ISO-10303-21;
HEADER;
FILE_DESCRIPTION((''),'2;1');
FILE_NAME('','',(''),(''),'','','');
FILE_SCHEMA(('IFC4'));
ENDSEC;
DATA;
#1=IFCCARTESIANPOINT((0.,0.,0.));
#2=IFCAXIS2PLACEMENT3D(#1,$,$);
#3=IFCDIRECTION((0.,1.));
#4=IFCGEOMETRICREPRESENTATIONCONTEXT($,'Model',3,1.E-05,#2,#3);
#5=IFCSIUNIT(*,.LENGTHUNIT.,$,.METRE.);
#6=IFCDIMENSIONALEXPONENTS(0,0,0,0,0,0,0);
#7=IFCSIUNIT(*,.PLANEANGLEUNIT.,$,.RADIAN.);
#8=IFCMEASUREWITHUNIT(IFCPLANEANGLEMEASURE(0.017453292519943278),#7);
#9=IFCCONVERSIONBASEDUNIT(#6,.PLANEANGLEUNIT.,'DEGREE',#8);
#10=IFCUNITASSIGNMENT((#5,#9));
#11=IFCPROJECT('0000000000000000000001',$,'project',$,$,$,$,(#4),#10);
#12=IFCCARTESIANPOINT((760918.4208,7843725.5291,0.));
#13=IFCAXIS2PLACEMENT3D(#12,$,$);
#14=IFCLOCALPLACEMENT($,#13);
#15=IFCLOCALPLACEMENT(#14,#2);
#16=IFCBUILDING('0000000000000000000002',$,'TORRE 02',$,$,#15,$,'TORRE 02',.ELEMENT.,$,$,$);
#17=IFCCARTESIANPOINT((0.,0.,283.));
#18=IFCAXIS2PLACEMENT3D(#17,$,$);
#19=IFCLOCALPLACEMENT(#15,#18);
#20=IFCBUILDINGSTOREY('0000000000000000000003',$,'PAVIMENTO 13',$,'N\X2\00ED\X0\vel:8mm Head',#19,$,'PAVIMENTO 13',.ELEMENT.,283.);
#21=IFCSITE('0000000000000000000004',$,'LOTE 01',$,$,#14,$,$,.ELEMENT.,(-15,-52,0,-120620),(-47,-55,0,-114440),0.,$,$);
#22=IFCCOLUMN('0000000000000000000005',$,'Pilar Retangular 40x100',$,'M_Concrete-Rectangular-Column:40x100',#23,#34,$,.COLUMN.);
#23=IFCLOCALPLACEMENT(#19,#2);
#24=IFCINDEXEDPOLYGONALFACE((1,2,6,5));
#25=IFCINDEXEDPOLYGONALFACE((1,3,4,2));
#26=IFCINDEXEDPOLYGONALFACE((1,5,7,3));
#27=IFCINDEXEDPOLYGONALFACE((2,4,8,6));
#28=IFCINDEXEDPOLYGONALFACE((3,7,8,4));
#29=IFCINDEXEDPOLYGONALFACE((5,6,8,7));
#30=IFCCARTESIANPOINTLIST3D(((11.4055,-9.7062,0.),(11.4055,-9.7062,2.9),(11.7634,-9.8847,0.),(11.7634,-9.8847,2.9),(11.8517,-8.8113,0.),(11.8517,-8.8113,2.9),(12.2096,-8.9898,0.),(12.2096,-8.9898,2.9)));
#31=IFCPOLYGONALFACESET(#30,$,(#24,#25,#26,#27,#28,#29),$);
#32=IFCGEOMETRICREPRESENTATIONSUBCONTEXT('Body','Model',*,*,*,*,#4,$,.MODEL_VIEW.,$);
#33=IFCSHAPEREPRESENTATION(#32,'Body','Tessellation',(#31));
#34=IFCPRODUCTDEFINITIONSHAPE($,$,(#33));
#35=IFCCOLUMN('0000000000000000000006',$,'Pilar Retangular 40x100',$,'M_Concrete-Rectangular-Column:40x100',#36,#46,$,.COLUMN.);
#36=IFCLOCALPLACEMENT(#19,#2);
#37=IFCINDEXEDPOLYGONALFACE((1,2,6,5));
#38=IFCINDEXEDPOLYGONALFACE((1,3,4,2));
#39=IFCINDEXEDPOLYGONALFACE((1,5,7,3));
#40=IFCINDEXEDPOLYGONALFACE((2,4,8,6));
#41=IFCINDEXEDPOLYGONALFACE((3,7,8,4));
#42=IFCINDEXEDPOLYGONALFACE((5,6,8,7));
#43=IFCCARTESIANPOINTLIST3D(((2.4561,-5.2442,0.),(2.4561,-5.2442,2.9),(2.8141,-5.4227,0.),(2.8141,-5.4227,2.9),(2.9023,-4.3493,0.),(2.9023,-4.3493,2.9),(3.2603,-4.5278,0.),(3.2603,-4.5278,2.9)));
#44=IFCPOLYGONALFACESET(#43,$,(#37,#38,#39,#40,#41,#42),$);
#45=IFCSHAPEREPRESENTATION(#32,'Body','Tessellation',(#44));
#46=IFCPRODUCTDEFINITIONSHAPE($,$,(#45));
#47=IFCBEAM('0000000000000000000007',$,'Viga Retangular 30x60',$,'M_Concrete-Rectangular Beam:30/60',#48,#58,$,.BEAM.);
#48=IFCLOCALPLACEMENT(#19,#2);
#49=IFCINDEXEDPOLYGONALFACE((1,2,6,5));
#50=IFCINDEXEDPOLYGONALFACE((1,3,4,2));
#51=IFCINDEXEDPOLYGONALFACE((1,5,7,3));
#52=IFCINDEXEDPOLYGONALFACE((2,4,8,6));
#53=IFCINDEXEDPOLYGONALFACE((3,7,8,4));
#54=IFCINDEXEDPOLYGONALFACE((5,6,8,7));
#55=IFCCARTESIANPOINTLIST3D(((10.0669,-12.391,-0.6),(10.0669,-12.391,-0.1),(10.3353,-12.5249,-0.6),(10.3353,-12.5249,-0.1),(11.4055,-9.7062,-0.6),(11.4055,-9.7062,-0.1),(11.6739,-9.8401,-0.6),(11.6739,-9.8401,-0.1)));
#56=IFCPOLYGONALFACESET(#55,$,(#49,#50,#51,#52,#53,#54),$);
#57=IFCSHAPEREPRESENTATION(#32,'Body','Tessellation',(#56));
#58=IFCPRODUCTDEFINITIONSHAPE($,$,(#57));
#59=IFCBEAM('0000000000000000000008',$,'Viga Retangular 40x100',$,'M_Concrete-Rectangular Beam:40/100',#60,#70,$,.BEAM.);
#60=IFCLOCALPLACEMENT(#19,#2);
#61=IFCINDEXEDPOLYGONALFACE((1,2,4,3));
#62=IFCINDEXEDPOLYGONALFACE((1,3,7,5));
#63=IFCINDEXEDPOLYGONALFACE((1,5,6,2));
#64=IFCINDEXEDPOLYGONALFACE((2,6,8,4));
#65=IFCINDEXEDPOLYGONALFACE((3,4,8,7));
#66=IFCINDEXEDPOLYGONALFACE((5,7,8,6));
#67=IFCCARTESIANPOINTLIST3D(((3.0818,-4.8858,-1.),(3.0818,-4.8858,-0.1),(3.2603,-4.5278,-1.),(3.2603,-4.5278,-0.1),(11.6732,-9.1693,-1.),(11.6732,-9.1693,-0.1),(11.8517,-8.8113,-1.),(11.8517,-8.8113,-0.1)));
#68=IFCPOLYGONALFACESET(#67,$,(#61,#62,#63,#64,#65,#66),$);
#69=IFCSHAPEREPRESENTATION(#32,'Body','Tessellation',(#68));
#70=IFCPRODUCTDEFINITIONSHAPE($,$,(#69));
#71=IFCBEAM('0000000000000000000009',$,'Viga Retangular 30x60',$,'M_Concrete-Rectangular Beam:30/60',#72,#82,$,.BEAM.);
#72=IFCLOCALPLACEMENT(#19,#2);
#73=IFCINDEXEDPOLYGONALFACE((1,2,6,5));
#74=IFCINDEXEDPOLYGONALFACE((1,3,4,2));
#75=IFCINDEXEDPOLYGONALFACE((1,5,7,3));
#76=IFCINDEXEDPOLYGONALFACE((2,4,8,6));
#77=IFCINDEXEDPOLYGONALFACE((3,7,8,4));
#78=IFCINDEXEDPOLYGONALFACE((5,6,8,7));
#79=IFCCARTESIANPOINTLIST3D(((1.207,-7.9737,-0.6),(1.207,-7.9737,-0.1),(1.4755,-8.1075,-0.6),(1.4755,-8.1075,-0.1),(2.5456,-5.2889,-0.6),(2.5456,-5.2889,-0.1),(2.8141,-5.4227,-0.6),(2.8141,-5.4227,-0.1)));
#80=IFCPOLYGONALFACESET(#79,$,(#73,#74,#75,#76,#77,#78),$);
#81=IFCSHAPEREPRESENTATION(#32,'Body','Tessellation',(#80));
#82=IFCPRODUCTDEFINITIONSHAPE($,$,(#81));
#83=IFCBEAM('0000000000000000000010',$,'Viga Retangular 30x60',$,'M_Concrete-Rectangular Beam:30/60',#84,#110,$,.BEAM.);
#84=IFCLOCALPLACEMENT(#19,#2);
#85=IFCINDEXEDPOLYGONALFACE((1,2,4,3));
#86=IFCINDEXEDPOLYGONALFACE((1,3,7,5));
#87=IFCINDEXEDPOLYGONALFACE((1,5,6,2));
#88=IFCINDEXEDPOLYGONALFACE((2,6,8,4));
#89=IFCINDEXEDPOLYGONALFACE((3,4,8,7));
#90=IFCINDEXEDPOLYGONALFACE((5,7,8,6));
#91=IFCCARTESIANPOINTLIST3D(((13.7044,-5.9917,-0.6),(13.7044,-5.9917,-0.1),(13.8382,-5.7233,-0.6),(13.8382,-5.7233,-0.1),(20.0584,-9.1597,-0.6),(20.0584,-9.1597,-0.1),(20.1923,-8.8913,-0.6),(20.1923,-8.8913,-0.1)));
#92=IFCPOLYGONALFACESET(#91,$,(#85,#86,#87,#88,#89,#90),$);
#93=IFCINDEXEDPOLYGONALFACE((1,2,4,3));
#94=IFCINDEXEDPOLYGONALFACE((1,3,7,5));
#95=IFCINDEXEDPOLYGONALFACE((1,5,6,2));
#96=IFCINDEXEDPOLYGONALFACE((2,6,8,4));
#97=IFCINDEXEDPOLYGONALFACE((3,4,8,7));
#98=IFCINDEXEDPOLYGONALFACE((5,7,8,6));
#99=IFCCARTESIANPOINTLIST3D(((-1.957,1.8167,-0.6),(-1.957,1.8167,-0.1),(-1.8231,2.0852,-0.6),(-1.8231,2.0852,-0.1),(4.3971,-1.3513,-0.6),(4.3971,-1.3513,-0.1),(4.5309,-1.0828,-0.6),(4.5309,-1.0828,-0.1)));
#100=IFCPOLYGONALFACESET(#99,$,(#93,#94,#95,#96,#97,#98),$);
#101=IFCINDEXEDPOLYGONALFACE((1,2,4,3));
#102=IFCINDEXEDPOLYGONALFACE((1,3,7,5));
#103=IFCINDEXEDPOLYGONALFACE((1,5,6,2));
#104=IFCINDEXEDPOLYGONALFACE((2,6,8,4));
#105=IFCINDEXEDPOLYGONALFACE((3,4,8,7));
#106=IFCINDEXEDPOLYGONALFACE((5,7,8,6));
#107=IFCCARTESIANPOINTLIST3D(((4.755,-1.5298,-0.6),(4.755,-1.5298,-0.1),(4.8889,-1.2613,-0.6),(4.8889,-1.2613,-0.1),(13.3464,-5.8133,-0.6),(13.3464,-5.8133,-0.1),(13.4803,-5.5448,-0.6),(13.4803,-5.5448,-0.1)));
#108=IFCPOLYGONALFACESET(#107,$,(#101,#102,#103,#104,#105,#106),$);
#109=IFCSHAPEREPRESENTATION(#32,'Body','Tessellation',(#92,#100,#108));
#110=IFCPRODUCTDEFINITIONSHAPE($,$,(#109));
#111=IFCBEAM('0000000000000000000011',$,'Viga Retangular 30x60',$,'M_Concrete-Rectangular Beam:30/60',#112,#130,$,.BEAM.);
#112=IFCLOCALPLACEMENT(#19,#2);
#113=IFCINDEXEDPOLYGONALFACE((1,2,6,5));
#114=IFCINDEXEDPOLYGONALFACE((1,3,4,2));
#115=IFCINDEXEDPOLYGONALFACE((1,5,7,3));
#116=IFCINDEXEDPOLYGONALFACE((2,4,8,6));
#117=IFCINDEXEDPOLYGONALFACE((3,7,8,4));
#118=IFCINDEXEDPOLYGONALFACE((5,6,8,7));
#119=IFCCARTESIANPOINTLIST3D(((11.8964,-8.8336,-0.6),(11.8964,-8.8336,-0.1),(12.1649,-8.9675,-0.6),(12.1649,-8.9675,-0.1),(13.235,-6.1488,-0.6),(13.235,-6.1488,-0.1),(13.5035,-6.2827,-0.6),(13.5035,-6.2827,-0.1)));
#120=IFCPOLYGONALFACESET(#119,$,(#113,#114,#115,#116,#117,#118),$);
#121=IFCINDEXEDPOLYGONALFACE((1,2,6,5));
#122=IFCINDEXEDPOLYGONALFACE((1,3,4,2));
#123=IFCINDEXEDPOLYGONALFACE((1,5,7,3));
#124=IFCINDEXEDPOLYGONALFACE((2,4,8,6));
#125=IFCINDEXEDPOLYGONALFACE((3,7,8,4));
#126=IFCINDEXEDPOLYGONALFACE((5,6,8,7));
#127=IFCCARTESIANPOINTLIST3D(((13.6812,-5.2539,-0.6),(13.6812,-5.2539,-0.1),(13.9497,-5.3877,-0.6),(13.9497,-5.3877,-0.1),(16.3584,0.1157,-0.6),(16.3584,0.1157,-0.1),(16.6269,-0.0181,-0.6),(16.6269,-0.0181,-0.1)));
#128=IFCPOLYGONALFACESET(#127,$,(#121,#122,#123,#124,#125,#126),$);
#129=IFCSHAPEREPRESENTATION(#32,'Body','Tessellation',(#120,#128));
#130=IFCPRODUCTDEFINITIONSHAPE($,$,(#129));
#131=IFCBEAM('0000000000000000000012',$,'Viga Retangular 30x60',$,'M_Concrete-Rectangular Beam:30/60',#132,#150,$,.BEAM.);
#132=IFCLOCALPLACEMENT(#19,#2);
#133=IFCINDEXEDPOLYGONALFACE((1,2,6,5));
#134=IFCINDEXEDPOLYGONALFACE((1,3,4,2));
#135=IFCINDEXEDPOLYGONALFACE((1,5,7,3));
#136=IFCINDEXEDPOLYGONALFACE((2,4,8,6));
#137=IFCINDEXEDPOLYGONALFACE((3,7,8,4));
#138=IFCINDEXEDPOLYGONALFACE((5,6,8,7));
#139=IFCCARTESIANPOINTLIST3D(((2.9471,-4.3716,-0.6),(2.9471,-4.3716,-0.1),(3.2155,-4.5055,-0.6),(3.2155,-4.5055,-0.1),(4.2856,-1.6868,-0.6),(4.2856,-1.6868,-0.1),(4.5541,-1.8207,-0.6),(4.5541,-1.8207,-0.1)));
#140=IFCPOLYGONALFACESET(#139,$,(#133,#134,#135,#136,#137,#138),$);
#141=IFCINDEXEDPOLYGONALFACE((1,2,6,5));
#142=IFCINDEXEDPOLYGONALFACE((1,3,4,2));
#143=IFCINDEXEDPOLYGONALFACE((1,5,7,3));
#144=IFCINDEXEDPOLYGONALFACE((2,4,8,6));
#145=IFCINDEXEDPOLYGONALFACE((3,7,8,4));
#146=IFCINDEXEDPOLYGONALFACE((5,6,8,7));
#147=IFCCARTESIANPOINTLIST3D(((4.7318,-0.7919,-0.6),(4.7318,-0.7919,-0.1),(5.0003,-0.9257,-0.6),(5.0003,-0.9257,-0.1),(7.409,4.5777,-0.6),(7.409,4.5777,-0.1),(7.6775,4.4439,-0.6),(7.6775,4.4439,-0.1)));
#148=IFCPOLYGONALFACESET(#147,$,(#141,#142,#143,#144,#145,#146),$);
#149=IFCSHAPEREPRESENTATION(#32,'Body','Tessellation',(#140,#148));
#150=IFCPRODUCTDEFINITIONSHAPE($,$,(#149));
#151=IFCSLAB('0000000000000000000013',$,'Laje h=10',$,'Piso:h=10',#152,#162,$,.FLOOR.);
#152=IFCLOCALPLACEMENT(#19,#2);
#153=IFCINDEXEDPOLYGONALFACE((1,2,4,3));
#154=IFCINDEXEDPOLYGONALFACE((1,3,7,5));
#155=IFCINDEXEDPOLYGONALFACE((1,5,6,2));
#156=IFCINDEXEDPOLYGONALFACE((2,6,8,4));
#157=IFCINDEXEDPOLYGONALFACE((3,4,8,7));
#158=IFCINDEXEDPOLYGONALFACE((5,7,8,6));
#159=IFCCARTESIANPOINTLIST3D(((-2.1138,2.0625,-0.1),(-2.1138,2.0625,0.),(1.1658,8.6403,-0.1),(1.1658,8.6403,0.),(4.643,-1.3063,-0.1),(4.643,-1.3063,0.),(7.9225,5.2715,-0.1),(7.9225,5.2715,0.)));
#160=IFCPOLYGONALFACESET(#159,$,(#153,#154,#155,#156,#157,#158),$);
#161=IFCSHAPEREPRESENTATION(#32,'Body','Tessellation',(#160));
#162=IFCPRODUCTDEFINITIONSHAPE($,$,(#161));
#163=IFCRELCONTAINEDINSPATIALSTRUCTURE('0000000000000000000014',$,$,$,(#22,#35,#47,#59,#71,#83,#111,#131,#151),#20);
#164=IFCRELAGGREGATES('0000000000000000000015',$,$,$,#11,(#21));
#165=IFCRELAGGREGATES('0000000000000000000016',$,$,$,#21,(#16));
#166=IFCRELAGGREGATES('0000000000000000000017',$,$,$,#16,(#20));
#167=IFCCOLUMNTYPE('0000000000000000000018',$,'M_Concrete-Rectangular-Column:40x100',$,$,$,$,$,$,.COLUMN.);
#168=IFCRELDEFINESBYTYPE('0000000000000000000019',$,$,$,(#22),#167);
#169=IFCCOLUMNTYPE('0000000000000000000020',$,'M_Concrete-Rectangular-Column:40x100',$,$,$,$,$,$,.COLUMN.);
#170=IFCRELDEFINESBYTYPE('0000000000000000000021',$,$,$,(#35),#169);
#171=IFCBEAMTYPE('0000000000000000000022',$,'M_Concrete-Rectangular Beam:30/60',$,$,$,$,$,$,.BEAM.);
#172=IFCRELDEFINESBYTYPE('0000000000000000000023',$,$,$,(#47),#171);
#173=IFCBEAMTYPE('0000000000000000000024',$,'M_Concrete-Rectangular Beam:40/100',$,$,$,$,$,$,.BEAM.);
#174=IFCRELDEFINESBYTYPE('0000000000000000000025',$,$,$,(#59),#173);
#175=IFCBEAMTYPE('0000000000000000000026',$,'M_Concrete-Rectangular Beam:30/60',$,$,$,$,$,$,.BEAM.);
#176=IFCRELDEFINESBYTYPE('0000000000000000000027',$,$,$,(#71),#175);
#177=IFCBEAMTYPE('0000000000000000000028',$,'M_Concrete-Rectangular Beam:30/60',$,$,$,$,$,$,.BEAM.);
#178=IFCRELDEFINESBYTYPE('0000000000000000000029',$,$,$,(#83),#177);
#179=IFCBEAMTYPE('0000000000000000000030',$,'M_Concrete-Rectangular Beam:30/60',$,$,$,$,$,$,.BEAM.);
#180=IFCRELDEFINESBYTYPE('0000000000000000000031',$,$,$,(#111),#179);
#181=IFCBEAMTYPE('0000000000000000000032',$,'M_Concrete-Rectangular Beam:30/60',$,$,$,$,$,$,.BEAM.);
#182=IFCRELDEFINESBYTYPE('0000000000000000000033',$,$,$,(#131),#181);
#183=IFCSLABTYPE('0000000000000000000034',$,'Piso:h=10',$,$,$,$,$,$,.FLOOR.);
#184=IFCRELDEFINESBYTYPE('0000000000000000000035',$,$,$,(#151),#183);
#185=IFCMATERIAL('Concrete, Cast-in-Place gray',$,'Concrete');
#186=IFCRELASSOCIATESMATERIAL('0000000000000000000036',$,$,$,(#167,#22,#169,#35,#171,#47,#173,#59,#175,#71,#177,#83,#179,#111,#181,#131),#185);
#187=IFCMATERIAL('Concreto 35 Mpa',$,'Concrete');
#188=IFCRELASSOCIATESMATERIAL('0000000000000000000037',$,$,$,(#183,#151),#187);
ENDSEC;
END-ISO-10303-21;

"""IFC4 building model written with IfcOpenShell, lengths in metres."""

from ifc_helpers import new_model, entity, si_unit, converted_unit, direction, frame, origin, place, context, subcontext, project, spatial, indexed_curve, outline, extrude, source, transform, mapped, material, type_object, type_shapes, element, save


model = new_model("IFC4")

# Units and contexts
model_context = context("Model", 3, precision=1e-05, world=origin(), true_north=direction((0.0, 1.0)))
body_context = subcontext(model_context, "Body", "Model", "MODEL_VIEW")
ifc_project = project(units=[si_unit("LENGTHUNIT", "METRE"), converted_unit("PLANEANGLEUNIT", "DEGREE", entity("IfcPlaneAngleMeasure", 0.017453292519943278), si_unit("PLANEANGLEUNIT", "RADIAN"), dimensions=[0, 0, 0, 0, 0, 0, 0])], contexts=[model_context])

# Site, building, storey
site_placement = place(None, frame((760918.4208, 7843725.5291, 0.0)))
site = spatial("IfcSite", under=ifc_project, at=site_placement, Name="LOTE 01", CompositionType="ELEMENT", RefLatitude=(-15, -52, 0, -120620), RefLongitude=(-47, -55, 0, -114440), RefElevation=0.0)
building_placement = place(site_placement, origin())
building = spatial("IfcBuilding", under=site, at=building_placement, Name="TORRE 02", LongName="TORRE 02", CompositionType="ELEMENT")
storey_placement = place(building_placement, frame((0.0, 0.0, 283.0)))
storey = spatial("IfcBuildingStorey", under=building, at=storey_placement, Name="PAVIMENTO 13", ObjectType="Nível:8mm Head", LongName="PAVIMENTO 13", CompositionType="ELEMENT", Elevation=283.0)

# Columns
ifc_material_1 = material(Name="Concrete, Cast-in-Place gray", Category="Concrete")
column_type_1 = type_object("IfcColumnType", Name="M_Concrete-Rectangular-Column:40x100", PredefinedType="COLUMN", material=ifc_material_1)
shared_shape_1 = source(origin(), body_context, "Body", "SweptSolid", [
    extrude(outline(indexed_curve([(-1.45, -0.2), (1.45, -0.2), (1.45, 0.2), (-1.45, 0.2), (-1.45, -0.2)], self_intersect=False)), frame((11.5844, -9.7955, 284.45), z_axis=(0.446198, 0.894934, 0.0), x_axis=(0.0, 0.0, 1.0)), (0.0, 0.0, 1.0), 1.0),
])
type_shapes(column_type_1, [shared_shape_1])
column_1_placement = place(storey_placement, frame((0.0, 0.0, -283.0)))
element("IfcColumn", 1, at=column_1_placement, inside=storey, type_object=column_type_1, material=ifc_material_1, Name="Pilar Retangular 40x100", ObjectType="M_Concrete-Rectangular-Column:40x100", PredefinedType="COLUMN", context=body_context, shape_type="MappedRepresentation", body=[
    mapped(shared_shape_1, transform((0.0, 0.0, 0.0), scale=1.0)),
])
column_type_2 = type_object("IfcColumnType", Name="M_Concrete-Rectangular-Column:40x100", PredefinedType="COLUMN", material=ifc_material_1)
shared_shape_2 = source(origin(), body_context, "Body", "SweptSolid", [
    extrude(outline(indexed_curve([(-1.45, -0.2), (1.45, -0.2), (1.45, 0.2), (-1.45, 0.2), (-1.45, -0.2)], self_intersect=False)), frame((2.6351, -5.3335, 284.45), z_axis=(0.446198, 0.894934, 0.0), x_axis=(0.0, 0.0, 1.0)), (0.0, 0.0, 1.0), 1.0),
])
type_shapes(column_type_2, [shared_shape_2])
column_2_placement = place(storey_placement, frame((0.0, 0.0, -283.0)))
element("IfcColumn", 2, at=column_2_placement, inside=storey, type_object=column_type_2, material=ifc_material_1, Name="Pilar Retangular 40x100", ObjectType="M_Concrete-Rectangular-Column:40x100", PredefinedType="COLUMN", context=body_context, shape_type="MappedRepresentation", body=[
    mapped(shared_shape_2, transform((0.0, 0.0, 0.0), scale=1.0)),
])

# Beams
beam_type_1 = type_object("IfcBeamType", Name="M_Concrete-Rectangular Beam:30/60", PredefinedType="BEAM", material=ifc_material_1)
shared_shape_3 = source(origin(), body_context, "Body", "SweptSolid", [
    extrude(outline(indexed_curve([(-0.25, -0.15), (0.25, -0.15), (0.25, 0.15), (-0.25, 0.15), (-0.25, -0.15)], self_intersect=False)), frame((10.2011, -12.458, 282.65), z_axis=(0.446198, 0.894934, 0.0), x_axis=(0.0, 0.0, 1.0)), (0.0, 0.0, 1.0), 3.0),
])
type_shapes(beam_type_1, [shared_shape_3])
beam_1_placement = place(storey_placement, frame((0.0, 0.0, -283.0)))
element("IfcBeam", 3, at=beam_1_placement, inside=storey, type_object=beam_type_1, material=ifc_material_1, Name="Viga Retangular 30x60", ObjectType="M_Concrete-Rectangular Beam:30/60", PredefinedType="BEAM", context=body_context, shape_type="MappedRepresentation", body=[
    mapped(shared_shape_3, transform((0.0, 0.0, 0.0), scale=1.0)),
])
beam_type_2 = type_object("IfcBeamType", Name="M_Concrete-Rectangular Beam:40/100", PredefinedType="BEAM", material=ifc_material_1)
shared_shape_4 = source(origin(), body_context, "Body", "SweptSolid", [
    extrude(outline(indexed_curve([(-0.45, -0.2), (0.45, -0.2), (0.45, 0.2), (-0.45, 0.2), (-0.45, -0.2)], self_intersect=False)), frame((11.7624, -8.9903, 282.45), z_axis=(-0.894934, 0.446198, 0.0), x_axis=(0.0, 0.0, 1.0)), (0.0, 0.0, 1.0), 9.6),
])
type_shapes(beam_type_2, [shared_shape_4])
beam_2_placement = place(storey_placement, frame((0.0, 0.0, -283.0)))
element("IfcBeam", 4, at=beam_2_placement, inside=storey, type_object=beam_type_2, material=ifc_material_1, Name="Viga Retangular 40x100", ObjectType="M_Concrete-Rectangular Beam:40/100", PredefinedType="BEAM", context=body_context, shape_type="MappedRepresentation", body=[
    mapped(shared_shape_4, transform((0.0, 0.0, 0.0), scale=1.0)),
])
beam_type_3 = type_object("IfcBeamType", Name="M_Concrete-Rectangular Beam:30/60", PredefinedType="BEAM", material=ifc_material_1)
shared_shape_5 = source(origin(), body_context, "Body", "SweptSolid", [
    extrude(outline(indexed_curve([(-0.25, -0.15), (0.25, -0.15), (0.25, 0.15), (-0.25, 0.15), (-0.25, -0.15)], self_intersect=False)), frame((2.6798, -5.3558, 282.65), z_axis=(-0.446198, -0.894934, 0.0), x_axis=(0.0, 0.0, -1.0)), (0.0, 0.0, 1.0), 3.0),
])
type_shapes(beam_type_3, [shared_shape_5])
beam_3_placement = place(storey_placement, frame((0.0, 0.0, -283.0)))
element("IfcBeam", 5, at=beam_3_placement, inside=storey, type_object=beam_type_3, material=ifc_material_1, Name="Viga Retangular 30x60", ObjectType="M_Concrete-Rectangular Beam:30/60", PredefinedType="BEAM", context=body_context, shape_type="MappedRepresentation", body=[
    mapped(shared_shape_5, transform((0.0, 0.0, 0.0), scale=1.0)),
])
beam_type_4 = type_object("IfcBeamType", Name="M_Concrete-Rectangular Beam:30/60", PredefinedType="BEAM", material=ifc_material_1)
shared_shape_6 = source(origin(), body_context, "Body", "SweptSolid", [
    extrude(outline(indexed_curve([(-0.25, -0.15), (0.25, -0.15), (0.25, 0.15), (-0.25, 0.15), (-0.25, -0.15)], self_intersect=False)), frame((13.7713, -5.8575, 282.65), z_axis=(0.894934, -0.446198, 0.0), x_axis=(0.0, 0.0, -1.0)), (0.0, 0.0, 1.0), 7.1),
    extrude(outline(indexed_curve([(-0.25, -0.15), (0.25, -0.15), (0.25, 0.15), (-0.25, 0.15), (-0.25, -0.15)], self_intersect=False)), frame((-1.89, 1.951, 282.65), z_axis=(0.894934, -0.446198, 0.0), x_axis=(0.0, 0.0, -1.0)), (0.0, 0.0, 1.0), 7.1),
    extrude(outline(indexed_curve([(-0.25, -0.15), (0.25, -0.15), (0.25, 0.15), (-0.25, 0.15), (-0.25, -0.15)], self_intersect=False)), frame((4.822, -1.3955, 282.65), z_axis=(0.894934, -0.446198, 0.0), x_axis=(0.0, 0.0, -1.0)), (0.0, 0.0, 1.0), 9.6),
])
type_shapes(beam_type_4, [shared_shape_6])
beam_4_placement = place(storey_placement, frame((0.0, 0.0, -283.0)))
element("IfcBeam", 6, at=beam_4_placement, inside=storey, type_object=beam_type_4, material=ifc_material_1, Name="Viga Retangular 30x60", ObjectType="M_Concrete-Rectangular Beam:30/60", PredefinedType="BEAM", context=body_context, shape_type="MappedRepresentation", body=[
    mapped(shared_shape_6, transform((0.0, 0.0, 0.0), scale=1.0)),
])
beam_type_5 = type_object("IfcBeamType", Name="M_Concrete-Rectangular Beam:30/60", PredefinedType="BEAM", material=ifc_material_1)
shared_shape_7 = source(origin(), body_context, "Body", "SweptSolid", [
    extrude(outline(indexed_curve([(-0.25, -0.15), (0.25, -0.15), (0.25, 0.15), (-0.25, 0.15), (-0.25, -0.15)], self_intersect=False)), frame((12.0306, -8.9005, 282.65), z_axis=(0.446198, 0.894934, 0.0), x_axis=(0.0, 0.0, 1.0)), (0.0, 0.0, 1.0), 3.0),
    extrude(outline(indexed_curve([(-0.25, -0.15), (0.25, -0.15), (0.25, 0.15), (-0.25, 0.15), (-0.25, -0.15)], self_intersect=False)), frame((13.8154, -5.3208, 282.65), z_axis=(0.446198, 0.894934, 0.0), x_axis=(0.0, 0.0, 1.0)), (0.0, 0.0, 1.0), 6.0),
])
type_shapes(beam_type_5, [shared_shape_7])
beam_5_placement = place(storey_placement, frame((0.0, 0.0, -283.0)))
element("IfcBeam", 7, at=beam_5_placement, inside=storey, type_object=beam_type_5, material=ifc_material_1, Name="Viga Retangular 30x60", ObjectType="M_Concrete-Rectangular Beam:30/60", PredefinedType="BEAM", context=body_context, shape_type="MappedRepresentation", body=[
    mapped(shared_shape_7, transform((0.0, 0.0, 0.0), scale=1.0)),
])
beam_type_6 = type_object("IfcBeamType", Name="M_Concrete-Rectangular Beam:30/60", PredefinedType="BEAM", material=ifc_material_1)
shared_shape_8 = source(origin(), body_context, "Body", "SweptSolid", [
    extrude(outline(indexed_curve([(-0.25, -0.15), (0.25, -0.15), (0.25, 0.15), (-0.25, 0.15), (-0.25, -0.15)], self_intersect=False)), frame((3.0813, -4.4385, 282.65), z_axis=(0.446198, 0.894934, 0.0), x_axis=(0.0, 0.0, 1.0)), (0.0, 0.0, 1.0), 3.0),
    extrude(outline(indexed_curve([(-0.25, -0.15), (0.25, -0.15), (0.25, 0.15), (-0.25, 0.15), (-0.25, -0.15)], self_intersect=False)), frame((4.8661, -0.8588, 282.65), z_axis=(0.446198, 0.894934, 0.0), x_axis=(0.0, 0.0, 1.0)), (0.0, 0.0, 1.0), 6.0),
])
type_shapes(beam_type_6, [shared_shape_8])
beam_6_placement = place(storey_placement, frame((0.0, 0.0, -283.0)))
element("IfcBeam", 8, at=beam_6_placement, inside=storey, type_object=beam_type_6, material=ifc_material_1, Name="Viga Retangular 30x60", ObjectType="M_Concrete-Rectangular Beam:30/60", PredefinedType="BEAM", context=body_context, shape_type="MappedRepresentation", body=[
    mapped(shared_shape_8, transform((0.0, 0.0, 0.0), scale=1.0)),
])

# Slab
ifc_material_2 = material(Name="Concreto 35 Mpa", Category="Concrete")
slab_type = type_object("IfcSlabType", Name="Piso:h=10", PredefinedType="FLOOR", material=ifc_material_2)
slab_1_placement = place(storey_placement, origin())
element("IfcSlab", 9, at=slab_1_placement, inside=storey, type_object=slab_type, material=ifc_material_2, Name="Laje h=10", ObjectType="Piso:h=10", PredefinedType="FLOOR", context=body_context, shape_type="SweptSolid", body=[
    extrude(outline(indexed_curve([(-3.675, -3.775), (3.675, -3.775), (3.675, 3.775), (-3.675, 3.775), (-3.675, -3.775)], self_intersect=False)), frame((2.9044, 3.667, 0.0), z_axis=(0.0, 0.0, -1.0), x_axis=(-0.446198, -0.894934, 0.0)), (0.0, 0.0, 1.0), 0.1),
])

save(model, "model.ifc")
